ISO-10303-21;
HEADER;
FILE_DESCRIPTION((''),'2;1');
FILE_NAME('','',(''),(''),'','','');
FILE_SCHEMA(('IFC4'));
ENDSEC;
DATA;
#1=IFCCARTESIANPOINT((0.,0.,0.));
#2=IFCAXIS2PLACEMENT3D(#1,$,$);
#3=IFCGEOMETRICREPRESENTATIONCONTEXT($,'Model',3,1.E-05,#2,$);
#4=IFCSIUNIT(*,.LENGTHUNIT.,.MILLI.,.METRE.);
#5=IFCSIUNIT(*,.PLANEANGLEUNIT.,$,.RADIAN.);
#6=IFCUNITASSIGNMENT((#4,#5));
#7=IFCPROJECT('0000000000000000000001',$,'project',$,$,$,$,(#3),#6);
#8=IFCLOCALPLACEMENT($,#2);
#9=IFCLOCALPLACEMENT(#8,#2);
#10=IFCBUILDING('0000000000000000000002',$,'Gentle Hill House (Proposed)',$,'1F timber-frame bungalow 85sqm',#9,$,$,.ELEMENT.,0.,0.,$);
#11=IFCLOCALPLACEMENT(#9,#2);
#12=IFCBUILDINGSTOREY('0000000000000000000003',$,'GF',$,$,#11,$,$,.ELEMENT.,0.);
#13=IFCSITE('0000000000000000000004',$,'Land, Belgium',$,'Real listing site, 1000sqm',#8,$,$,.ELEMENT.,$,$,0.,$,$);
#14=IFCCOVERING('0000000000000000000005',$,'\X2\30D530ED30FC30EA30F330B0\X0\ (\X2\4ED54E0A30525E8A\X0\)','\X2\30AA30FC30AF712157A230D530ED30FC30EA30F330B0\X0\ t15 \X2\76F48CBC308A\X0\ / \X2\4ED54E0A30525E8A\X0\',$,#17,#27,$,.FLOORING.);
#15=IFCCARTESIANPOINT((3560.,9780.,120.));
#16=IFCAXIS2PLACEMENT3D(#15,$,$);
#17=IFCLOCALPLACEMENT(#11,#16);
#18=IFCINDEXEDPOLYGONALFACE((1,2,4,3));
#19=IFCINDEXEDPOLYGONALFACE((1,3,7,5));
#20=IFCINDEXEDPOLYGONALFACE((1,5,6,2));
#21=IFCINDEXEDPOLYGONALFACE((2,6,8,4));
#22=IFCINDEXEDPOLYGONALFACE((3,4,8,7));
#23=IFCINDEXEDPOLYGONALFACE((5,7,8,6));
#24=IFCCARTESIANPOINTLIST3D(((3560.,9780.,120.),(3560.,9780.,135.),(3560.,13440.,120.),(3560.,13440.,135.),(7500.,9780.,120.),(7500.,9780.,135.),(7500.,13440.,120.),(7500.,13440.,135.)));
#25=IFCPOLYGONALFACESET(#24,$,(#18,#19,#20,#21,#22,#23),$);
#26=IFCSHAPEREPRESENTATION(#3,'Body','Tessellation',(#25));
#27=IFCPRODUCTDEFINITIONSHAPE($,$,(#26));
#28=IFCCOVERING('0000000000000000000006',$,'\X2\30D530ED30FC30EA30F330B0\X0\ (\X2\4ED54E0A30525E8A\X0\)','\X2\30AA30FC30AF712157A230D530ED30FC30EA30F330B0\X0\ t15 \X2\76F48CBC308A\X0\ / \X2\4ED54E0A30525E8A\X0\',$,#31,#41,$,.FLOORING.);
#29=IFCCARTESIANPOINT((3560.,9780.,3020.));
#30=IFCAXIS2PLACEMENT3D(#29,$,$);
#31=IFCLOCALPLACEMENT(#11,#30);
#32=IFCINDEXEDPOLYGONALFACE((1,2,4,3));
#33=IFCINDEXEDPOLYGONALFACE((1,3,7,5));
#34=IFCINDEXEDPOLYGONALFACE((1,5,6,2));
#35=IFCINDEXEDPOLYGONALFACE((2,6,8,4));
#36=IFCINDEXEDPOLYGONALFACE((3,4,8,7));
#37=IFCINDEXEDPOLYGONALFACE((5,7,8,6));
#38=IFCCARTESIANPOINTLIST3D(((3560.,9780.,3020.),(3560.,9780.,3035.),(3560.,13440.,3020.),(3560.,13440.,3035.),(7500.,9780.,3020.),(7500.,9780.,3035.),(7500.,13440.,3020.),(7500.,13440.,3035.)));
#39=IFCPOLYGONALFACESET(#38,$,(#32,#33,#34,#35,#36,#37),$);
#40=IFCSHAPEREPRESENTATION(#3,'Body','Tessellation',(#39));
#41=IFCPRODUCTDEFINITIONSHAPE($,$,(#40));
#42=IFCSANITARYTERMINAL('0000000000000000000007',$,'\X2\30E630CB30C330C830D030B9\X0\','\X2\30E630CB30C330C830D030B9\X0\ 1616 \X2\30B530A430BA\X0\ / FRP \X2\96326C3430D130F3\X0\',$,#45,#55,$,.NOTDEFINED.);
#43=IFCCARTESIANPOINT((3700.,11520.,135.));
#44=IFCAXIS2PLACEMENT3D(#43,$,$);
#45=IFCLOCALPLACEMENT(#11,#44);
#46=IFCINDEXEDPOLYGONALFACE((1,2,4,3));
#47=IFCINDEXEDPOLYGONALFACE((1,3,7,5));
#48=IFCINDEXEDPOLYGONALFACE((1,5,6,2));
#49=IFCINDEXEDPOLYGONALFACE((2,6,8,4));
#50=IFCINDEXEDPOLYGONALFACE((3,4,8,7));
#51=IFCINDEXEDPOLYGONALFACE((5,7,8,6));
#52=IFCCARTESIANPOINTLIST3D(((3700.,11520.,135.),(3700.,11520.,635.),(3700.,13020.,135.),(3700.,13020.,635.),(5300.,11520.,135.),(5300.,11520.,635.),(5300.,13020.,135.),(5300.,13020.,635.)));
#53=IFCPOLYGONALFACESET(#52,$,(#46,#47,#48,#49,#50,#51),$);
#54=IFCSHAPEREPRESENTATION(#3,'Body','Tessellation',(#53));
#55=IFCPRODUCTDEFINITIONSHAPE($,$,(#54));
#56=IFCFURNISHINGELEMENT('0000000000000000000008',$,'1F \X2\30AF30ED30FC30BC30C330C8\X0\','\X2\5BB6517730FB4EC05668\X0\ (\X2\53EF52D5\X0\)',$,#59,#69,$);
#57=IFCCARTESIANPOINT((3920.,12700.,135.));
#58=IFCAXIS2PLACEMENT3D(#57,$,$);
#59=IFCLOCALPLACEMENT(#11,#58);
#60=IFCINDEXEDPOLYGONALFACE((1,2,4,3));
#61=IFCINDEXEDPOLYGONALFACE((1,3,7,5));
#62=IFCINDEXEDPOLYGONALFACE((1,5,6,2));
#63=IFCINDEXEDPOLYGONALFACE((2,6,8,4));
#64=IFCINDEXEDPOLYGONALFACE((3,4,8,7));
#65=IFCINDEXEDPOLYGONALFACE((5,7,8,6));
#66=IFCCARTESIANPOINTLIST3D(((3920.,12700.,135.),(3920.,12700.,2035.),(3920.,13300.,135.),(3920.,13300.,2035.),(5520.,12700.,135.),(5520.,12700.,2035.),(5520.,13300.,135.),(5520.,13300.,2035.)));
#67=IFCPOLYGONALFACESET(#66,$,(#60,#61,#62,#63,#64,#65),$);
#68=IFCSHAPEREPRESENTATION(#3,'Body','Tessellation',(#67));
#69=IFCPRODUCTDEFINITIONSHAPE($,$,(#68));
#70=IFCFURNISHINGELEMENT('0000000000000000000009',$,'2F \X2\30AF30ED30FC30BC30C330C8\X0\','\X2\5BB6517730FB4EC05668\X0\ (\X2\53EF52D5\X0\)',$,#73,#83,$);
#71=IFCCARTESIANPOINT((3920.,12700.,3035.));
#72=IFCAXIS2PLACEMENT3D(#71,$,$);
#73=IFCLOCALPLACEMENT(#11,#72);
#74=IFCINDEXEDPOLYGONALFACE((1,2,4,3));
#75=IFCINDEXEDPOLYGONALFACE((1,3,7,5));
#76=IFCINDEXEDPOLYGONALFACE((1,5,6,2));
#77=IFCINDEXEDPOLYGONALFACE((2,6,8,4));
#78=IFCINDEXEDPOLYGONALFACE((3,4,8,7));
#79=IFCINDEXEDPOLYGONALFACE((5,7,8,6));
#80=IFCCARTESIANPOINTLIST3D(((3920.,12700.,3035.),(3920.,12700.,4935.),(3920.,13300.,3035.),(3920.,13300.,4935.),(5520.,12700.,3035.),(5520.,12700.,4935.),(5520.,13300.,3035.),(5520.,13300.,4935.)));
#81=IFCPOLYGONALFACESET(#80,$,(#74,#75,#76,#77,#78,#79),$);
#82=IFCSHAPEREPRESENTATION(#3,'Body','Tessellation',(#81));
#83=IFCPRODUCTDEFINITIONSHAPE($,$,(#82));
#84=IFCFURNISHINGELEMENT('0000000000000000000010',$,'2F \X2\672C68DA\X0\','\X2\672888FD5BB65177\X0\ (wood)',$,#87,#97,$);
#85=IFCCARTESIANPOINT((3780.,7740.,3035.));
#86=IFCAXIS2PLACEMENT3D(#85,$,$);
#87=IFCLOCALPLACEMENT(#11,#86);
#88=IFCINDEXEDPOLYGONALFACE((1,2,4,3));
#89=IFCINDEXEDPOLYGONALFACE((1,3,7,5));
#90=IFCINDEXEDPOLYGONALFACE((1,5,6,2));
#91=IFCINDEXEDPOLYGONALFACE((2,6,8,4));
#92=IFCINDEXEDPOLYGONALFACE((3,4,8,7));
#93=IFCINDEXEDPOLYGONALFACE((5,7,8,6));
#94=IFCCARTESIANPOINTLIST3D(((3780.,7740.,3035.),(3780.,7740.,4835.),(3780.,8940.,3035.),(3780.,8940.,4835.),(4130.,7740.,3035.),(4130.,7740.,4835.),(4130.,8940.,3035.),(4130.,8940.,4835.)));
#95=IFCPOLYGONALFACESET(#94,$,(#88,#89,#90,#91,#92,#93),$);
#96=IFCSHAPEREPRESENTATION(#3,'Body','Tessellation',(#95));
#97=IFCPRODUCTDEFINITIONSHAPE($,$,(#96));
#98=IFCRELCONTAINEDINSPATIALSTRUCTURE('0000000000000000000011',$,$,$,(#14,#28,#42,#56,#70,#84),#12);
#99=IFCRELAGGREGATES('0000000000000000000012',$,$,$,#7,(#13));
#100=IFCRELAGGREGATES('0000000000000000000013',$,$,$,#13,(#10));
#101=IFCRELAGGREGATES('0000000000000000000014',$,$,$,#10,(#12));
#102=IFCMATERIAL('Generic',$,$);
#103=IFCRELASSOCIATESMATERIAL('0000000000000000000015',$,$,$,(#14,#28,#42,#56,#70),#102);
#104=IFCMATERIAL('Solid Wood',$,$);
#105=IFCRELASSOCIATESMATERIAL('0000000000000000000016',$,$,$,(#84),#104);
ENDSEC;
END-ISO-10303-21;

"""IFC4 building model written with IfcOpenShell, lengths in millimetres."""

from ifc_helpers import new_model, si_unit, frame, frame_2d, origin, place, context, project, spatial, rectangle, extrude, material, element, save


model = new_model("IFC4")

# Units and contexts
model_context = context("Model", 3, precision=1e-05, world=origin())
ifc_project = project(units=[si_unit("LENGTHUNIT", "METRE", prefix="MILLI"), si_unit("PLANEANGLEUNIT", "RADIAN")], contexts=[model_context])

# Site, building, storey
site_placement = place(None, origin())
site = spatial("IfcSite", under=ifc_project, at=site_placement, Name="Land, Belgium", ObjectType="Real listing site, 1000sqm", CompositionType="ELEMENT", RefElevation=0.0)
building_placement = place(site_placement, origin())
building = spatial("IfcBuilding", under=site, at=building_placement, Name="Gentle Hill House (Proposed)", ObjectType="1F timber-frame bungalow 85sqm", CompositionType="ELEMENT", ElevationOfRefHeight=0.0, ElevationOfTerrain=0.0)
storey_placement = place(building_placement, origin())
storey = spatial("IfcBuildingStorey", under=building, at=storey_placement, Name="GF", CompositionType="ELEMENT", Elevation=0.0)

# Shared definitions
ifc_material_1 = material(Name="Solid Wood")

# Coverings
ifc_material_2 = material(Name="Generic")
covering_1_placement = place(storey_placement, frame((3560.0, 9780.0, 120.0)))
element("IfcCovering", 1, at=covering_1_placement, inside=storey, material=ifc_material_2, Name="フローリング (仕上げ床)", Description="オーク無垢フローリング t15 直貼り / 仕上げ床", PredefinedType="FLOORING", context=model_context, shape_type="SweptSolid", body=[
    extrude(rectangle(XDim=3940.0, YDim=3660.0, at=frame_2d((1970.0, 1830.0))), frame((3560.0, 9780.0, 120.0)), (0.0, 0.0, 1.0), 15.0),
])
covering_2_placement = place(storey_placement, frame((3560.0, 9780.0, 3020.0)))
element("IfcCovering", 2, at=covering_2_placement, inside=storey, material=ifc_material_2, Name="フローリング (仕上げ床)", Description="オーク無垢フローリング t15 直貼り / 仕上げ床", PredefinedType="FLOORING", context=model_context, shape_type="SweptSolid", body=[
    extrude(rectangle(XDim=3940.0, YDim=3660.0, at=frame_2d((1970.0, 1830.0))), frame((3560.0, 9780.0, 3020.0)), (0.0, 0.0, 1.0), 15.0),
])

# Sanitary terminal
sanitary_terminal_placement = place(storey_placement, frame((3700.0, 11520.0, 135.0)))
element("IfcSanitaryTerminal", 3, at=sanitary_terminal_placement, inside=storey, material=ifc_material_2, Name="ユニットバス", Description="ユニットバス 1616 サイズ / FRP 防水パン", PredefinedType="NOTDEFINED", context=model_context, shape_type="SweptSolid", body=[
    extrude(rectangle(XDim=1600.0, YDim=1500.0, at=frame_2d((800.0, 750.0))), frame((3700.0, 11520.0, 135.0)), (0.0, 0.0, 1.0), 500.0),
])

# Furnishing elements
furnishing_1_placement = place(storey_placement, frame((3920.0, 12700.0, 135.0)))
element("IfcFurnishingElement", 4, at=furnishing_1_placement, inside=storey, material=ifc_material_2, Name="1F クローゼット", Description="家具・什器 (可動)", context=model_context, shape_type="SweptSolid", body=[
    extrude(rectangle(XDim=1600.0, YDim=600.0, at=frame_2d((800.0, 300.0))), frame((3920.0, 12700.0, 135.0)), (0.0, 0.0, 1.0), 1900.0),
])
furnishing_2_placement = place(storey_placement, frame((3920.0, 12700.0, 3035.0)))
element("IfcFurnishingElement", 5, at=furnishing_2_placement, inside=storey, material=ifc_material_2, Name="2F クローゼット", Description="家具・什器 (可動)", context=model_context, shape_type="SweptSolid", body=[
    extrude(rectangle(XDim=1600.0, YDim=600.0, at=frame_2d((800.0, 300.0))), frame((3920.0, 12700.0, 3035.0)), (0.0, 0.0, 1.0), 1900.0),
])
furnishing_3_placement = place(storey_placement, frame((3780.0, 7740.0, 3035.0)))
element("IfcFurnishingElement", 6, at=furnishing_3_placement, inside=storey, material=ifc_material_1, Name="2F 本棚", Description="木製家具 (wood)", context=model_context, shape_type="SweptSolid", body=[
    extrude(rectangle(XDim=350.0, YDim=1200.0, at=frame_2d((175.0, 600.0))), frame((3780.0, 7740.0, 3035.0)), (0.0, 0.0, 1.0), 1800.0),
])

save(model, "model.ifc")
